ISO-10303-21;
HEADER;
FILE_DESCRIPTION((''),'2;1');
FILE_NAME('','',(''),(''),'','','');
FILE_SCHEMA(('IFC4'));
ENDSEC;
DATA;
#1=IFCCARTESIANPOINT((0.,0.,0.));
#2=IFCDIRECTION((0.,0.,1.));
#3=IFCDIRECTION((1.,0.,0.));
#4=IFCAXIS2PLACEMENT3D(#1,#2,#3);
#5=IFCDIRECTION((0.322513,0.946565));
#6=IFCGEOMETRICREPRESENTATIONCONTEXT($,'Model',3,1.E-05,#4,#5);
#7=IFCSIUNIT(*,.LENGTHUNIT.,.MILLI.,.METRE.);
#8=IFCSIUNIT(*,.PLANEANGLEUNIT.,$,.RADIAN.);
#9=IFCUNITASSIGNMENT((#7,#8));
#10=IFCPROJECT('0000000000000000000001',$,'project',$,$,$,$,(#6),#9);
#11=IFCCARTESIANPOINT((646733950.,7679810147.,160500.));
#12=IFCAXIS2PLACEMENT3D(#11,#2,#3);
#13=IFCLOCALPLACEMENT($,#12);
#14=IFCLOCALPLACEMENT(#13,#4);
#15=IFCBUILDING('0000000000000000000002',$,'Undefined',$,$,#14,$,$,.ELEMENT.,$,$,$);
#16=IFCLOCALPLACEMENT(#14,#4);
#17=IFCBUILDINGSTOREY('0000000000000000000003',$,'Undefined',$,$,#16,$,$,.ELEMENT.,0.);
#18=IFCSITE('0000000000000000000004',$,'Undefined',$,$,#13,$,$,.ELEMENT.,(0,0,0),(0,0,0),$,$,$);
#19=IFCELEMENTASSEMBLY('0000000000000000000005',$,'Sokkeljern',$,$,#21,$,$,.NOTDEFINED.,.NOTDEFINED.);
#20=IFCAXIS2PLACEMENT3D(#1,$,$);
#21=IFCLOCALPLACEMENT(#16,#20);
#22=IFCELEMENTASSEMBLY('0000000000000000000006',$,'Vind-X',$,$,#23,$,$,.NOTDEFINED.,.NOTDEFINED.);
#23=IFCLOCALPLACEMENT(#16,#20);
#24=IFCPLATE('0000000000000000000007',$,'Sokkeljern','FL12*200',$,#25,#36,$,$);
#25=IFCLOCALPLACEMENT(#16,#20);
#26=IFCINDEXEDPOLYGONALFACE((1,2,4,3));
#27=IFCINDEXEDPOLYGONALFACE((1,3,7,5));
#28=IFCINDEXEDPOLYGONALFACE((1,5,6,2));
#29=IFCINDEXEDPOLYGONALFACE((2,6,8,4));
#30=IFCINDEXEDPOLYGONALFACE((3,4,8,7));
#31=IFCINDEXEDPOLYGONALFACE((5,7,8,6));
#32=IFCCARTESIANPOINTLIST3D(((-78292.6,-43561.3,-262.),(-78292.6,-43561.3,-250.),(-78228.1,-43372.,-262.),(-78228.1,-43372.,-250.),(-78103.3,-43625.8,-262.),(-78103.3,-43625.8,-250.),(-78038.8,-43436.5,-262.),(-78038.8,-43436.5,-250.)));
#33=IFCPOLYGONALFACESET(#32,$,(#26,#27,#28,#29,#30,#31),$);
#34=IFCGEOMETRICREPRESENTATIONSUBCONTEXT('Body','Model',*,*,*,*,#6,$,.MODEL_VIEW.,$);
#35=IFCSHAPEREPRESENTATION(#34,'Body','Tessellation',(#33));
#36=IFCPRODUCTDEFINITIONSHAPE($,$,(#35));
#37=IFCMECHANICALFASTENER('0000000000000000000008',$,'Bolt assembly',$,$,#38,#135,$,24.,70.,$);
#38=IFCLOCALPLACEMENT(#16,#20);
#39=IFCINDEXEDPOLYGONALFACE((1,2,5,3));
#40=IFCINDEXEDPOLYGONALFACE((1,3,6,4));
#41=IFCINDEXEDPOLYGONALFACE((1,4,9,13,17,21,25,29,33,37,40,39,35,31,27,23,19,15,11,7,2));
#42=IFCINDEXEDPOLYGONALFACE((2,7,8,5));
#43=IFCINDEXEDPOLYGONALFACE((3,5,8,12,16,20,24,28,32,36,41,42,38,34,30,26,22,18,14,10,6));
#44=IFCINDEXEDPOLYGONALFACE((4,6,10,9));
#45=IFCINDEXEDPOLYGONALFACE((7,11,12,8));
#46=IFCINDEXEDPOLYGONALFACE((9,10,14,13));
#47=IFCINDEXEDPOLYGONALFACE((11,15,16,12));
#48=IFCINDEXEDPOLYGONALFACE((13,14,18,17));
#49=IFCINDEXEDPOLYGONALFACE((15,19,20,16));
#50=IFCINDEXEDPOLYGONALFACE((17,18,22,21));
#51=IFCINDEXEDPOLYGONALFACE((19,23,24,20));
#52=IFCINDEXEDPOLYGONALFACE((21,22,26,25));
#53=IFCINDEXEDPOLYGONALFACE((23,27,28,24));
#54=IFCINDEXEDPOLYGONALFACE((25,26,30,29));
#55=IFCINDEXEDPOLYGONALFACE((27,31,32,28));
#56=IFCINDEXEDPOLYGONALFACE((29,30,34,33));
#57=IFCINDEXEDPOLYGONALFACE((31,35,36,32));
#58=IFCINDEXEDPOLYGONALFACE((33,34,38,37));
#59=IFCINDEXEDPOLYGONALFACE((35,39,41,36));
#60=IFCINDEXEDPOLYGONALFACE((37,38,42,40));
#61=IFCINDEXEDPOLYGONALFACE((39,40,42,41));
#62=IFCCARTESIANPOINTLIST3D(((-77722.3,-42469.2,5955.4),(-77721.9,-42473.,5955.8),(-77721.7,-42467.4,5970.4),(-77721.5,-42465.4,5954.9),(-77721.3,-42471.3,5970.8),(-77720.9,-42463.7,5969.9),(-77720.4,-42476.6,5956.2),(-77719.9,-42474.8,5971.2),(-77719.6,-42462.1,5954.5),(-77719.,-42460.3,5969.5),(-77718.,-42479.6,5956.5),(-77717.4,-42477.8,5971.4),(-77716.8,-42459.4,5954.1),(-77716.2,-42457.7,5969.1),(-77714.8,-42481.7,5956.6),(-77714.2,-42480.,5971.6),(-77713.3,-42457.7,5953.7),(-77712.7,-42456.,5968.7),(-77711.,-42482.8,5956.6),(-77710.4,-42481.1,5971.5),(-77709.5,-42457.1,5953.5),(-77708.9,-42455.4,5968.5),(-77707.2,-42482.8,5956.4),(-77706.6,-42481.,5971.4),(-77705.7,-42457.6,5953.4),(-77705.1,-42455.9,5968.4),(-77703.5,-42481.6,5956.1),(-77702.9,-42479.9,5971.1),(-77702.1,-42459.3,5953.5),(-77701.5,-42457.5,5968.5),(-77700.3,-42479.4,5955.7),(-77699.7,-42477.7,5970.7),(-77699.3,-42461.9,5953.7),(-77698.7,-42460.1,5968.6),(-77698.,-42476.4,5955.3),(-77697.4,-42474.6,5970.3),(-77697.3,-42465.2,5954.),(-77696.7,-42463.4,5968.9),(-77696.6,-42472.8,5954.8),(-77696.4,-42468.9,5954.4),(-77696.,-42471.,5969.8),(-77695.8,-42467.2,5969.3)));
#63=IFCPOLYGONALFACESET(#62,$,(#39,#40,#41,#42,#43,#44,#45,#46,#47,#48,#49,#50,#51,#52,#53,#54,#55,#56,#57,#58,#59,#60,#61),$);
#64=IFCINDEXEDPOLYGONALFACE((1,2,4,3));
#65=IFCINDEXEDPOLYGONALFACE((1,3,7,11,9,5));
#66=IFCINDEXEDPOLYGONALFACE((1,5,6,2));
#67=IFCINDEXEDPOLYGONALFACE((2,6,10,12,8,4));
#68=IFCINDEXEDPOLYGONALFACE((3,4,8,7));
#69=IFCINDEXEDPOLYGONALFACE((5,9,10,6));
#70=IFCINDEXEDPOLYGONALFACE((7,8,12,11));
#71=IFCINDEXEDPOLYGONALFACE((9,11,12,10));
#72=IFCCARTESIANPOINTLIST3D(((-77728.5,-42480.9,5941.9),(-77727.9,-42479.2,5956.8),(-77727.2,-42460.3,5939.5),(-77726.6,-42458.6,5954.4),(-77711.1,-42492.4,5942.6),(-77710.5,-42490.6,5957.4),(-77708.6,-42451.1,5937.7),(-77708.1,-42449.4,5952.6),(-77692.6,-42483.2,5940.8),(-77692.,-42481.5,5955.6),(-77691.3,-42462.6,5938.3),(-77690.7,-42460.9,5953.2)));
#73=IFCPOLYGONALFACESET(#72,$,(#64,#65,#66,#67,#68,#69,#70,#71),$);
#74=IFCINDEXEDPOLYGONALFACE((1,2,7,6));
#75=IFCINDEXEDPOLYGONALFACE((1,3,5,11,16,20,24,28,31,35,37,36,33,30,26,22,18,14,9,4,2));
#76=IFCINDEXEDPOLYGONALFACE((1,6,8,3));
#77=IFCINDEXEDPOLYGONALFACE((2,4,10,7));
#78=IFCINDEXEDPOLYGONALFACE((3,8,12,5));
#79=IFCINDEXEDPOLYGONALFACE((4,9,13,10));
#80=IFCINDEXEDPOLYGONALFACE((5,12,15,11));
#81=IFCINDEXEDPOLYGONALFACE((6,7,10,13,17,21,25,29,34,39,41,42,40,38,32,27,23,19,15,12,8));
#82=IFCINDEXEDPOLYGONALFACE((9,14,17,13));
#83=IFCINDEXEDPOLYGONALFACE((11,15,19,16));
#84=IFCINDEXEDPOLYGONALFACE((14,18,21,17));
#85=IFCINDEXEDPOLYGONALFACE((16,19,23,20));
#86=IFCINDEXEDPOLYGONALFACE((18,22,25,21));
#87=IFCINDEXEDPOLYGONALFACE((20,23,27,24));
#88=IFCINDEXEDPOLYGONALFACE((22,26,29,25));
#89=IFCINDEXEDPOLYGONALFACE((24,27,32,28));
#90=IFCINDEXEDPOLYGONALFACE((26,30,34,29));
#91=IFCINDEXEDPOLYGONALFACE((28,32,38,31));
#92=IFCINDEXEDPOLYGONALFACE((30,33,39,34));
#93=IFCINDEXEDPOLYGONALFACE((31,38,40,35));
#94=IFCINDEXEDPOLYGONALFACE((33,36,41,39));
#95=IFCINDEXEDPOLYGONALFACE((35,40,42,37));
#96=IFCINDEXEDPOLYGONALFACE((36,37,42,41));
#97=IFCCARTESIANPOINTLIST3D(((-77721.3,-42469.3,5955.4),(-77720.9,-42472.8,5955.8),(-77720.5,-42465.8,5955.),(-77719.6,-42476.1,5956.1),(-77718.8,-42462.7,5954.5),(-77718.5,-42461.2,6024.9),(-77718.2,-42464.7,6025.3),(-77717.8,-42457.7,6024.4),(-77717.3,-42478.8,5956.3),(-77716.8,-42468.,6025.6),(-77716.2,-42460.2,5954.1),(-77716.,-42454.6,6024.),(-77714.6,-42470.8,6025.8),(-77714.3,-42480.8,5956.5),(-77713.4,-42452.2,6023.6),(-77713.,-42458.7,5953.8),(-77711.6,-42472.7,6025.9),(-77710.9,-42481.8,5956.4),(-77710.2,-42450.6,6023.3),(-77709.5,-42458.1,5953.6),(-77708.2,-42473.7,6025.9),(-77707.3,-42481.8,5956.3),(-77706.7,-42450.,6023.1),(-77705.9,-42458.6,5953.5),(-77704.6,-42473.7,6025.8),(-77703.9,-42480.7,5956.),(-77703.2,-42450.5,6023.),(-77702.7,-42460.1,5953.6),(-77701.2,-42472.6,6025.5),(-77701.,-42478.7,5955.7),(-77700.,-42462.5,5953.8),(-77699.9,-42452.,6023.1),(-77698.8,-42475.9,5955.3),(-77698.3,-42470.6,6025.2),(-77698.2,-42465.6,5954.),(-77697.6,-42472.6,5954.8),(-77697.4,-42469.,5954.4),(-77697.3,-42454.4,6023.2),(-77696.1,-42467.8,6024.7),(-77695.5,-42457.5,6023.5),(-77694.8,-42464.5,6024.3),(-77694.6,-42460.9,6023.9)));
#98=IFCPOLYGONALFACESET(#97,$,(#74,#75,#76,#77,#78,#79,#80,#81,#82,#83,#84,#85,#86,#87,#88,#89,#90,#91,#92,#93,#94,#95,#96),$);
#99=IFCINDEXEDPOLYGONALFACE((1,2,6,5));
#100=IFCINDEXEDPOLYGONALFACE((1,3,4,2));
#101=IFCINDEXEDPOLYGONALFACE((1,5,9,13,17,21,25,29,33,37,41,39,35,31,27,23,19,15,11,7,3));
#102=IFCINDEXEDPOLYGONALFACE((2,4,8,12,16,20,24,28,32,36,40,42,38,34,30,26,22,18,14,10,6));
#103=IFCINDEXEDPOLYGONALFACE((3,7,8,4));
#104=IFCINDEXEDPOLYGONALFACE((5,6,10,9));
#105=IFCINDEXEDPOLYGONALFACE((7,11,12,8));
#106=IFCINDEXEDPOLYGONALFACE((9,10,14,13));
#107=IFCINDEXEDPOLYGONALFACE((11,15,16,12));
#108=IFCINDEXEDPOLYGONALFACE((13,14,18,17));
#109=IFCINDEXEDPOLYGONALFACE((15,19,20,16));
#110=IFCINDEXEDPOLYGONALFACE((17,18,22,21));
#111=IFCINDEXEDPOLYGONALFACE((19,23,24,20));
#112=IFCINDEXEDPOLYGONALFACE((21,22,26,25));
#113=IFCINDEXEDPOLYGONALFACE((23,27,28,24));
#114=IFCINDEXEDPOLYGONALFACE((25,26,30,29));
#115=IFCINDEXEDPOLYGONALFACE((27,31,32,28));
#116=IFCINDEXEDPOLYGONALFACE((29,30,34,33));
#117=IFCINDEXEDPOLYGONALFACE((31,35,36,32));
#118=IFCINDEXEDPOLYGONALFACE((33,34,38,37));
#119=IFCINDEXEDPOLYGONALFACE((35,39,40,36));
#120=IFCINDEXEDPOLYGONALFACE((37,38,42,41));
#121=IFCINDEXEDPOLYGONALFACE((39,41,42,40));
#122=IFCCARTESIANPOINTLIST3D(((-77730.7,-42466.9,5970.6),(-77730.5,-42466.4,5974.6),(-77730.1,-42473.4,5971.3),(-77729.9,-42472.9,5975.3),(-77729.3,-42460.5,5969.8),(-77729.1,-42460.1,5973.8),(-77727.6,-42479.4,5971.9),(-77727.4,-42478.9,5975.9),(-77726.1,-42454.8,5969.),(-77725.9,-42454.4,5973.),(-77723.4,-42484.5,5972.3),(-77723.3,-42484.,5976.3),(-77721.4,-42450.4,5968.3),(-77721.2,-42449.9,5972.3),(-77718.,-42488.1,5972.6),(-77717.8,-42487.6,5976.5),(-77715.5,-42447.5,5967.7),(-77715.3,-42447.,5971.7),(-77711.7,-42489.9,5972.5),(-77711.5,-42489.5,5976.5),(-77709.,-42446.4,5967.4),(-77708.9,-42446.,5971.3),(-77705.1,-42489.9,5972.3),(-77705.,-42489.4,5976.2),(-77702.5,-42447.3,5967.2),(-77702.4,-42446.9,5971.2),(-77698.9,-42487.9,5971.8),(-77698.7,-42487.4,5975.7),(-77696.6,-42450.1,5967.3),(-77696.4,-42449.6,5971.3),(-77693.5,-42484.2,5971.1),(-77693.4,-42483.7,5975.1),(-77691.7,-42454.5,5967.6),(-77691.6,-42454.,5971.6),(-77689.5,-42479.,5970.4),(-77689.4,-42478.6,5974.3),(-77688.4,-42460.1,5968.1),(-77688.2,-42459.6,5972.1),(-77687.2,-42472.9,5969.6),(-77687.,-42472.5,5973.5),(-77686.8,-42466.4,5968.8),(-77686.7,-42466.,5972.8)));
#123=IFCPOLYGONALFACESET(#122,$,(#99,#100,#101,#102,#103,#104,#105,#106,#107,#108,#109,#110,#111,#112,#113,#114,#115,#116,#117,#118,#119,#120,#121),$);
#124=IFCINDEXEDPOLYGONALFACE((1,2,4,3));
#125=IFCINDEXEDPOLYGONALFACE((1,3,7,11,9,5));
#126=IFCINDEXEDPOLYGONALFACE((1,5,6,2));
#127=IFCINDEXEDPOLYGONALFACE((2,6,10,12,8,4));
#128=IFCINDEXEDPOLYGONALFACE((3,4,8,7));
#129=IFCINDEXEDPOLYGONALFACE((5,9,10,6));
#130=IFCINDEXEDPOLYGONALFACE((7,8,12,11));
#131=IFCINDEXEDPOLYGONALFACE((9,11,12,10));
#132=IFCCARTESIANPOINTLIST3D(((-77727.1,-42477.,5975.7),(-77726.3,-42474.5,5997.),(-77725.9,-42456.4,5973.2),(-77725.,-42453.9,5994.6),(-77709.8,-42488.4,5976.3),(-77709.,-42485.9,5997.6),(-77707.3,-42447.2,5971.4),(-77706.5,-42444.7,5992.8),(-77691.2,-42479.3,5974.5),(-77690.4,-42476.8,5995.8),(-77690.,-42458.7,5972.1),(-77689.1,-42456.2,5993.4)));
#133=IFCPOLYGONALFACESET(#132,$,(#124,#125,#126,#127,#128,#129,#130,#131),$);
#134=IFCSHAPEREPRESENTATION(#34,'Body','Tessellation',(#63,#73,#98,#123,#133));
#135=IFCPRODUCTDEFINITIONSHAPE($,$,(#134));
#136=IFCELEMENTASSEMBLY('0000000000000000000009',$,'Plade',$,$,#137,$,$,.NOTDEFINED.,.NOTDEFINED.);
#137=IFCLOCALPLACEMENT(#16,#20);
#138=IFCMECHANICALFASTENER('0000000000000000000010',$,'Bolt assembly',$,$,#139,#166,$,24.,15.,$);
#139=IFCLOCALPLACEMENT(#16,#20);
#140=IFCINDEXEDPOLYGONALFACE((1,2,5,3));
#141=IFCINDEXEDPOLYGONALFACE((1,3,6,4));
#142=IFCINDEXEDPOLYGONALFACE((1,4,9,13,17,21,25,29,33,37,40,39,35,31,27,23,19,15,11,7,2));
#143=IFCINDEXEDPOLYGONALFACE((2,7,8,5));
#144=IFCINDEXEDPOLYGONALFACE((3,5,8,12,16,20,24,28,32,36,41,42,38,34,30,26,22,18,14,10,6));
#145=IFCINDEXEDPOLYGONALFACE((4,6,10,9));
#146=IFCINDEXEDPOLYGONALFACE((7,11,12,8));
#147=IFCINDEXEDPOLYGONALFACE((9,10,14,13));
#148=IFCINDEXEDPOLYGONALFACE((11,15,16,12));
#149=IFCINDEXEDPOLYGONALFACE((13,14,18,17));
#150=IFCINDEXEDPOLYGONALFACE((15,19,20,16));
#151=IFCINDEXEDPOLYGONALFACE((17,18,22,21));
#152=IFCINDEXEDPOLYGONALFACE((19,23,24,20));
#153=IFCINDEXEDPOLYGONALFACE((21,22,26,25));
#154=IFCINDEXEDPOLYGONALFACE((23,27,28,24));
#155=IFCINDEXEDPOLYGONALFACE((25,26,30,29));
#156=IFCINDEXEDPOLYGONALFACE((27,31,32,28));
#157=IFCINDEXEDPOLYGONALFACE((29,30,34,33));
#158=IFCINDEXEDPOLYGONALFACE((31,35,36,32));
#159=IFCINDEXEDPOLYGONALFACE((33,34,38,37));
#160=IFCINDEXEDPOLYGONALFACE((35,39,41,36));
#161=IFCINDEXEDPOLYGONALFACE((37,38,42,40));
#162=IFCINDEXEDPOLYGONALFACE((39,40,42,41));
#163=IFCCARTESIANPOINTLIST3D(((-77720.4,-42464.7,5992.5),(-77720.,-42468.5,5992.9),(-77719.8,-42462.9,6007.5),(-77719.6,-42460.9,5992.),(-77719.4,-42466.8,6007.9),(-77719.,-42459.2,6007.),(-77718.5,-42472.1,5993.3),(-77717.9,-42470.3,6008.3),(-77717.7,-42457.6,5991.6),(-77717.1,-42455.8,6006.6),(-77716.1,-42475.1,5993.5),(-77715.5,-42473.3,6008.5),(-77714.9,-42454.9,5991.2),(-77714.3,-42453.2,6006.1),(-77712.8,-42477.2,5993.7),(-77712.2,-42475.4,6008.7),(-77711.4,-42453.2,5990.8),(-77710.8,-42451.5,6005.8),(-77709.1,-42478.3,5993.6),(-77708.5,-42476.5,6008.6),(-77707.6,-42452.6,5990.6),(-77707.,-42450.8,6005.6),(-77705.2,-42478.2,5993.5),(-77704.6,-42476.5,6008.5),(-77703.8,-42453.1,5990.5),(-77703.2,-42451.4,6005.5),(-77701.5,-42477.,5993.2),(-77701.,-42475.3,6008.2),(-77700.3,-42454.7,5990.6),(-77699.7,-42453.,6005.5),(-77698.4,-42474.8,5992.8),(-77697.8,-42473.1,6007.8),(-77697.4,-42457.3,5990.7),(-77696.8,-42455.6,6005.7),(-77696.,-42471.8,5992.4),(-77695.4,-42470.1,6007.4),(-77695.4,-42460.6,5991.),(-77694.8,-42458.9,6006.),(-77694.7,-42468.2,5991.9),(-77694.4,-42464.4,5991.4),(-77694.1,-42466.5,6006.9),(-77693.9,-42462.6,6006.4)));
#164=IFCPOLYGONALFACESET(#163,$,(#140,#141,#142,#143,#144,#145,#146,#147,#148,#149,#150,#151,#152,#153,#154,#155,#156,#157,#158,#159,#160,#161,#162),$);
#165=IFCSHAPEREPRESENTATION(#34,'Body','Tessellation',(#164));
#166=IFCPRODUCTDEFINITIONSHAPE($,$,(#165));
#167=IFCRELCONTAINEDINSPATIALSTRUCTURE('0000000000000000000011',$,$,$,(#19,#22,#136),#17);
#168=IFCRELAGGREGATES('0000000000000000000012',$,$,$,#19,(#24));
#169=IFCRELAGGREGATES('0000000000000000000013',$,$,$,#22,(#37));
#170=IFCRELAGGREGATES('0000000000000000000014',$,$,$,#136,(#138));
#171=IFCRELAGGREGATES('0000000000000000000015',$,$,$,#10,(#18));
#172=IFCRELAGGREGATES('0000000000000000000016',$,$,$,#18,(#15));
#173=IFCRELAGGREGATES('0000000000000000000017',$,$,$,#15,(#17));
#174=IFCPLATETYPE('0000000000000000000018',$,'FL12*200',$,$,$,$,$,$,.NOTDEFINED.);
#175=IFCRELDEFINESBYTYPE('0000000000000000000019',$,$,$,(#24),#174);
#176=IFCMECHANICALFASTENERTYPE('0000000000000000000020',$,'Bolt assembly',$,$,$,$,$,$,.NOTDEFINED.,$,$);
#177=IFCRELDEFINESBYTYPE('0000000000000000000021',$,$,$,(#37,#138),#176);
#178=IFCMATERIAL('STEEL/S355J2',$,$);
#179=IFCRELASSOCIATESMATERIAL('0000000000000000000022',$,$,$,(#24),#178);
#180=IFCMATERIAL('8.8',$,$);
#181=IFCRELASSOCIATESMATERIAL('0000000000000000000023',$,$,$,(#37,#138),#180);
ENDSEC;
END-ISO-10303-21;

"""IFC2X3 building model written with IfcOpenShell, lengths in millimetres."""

from ifc_helpers import new_model, si_unit, direction, frame, origin_with_axes, origin_2d_with_axis, place, context, subcontext, project, spatial, polyline, circle, outline, extrude, source, transform, mapped, material, type_object, element, aggregate, save


model = new_model("IFC2X3")

# Units and contexts
model_context = context("Model", 3, precision=1e-05, world=origin_with_axes(), true_north=direction((0.322513, 0.946565)))
body_context = subcontext(model_context, "Body", "Model", "MODEL_VIEW")
ifc_project = project(units=[si_unit("LENGTHUNIT", "METRE", prefix="MILLI"), si_unit("PLANEANGLEUNIT", "RADIAN")], contexts=[model_context])

# Site, building, storey
site_placement = place(None, frame((646733950.0, 7679810147.0, 160500.0), z_axis=(0.0, 0.0, 1.0), x_axis=(1.0, 0.0, 0.0)))
site = spatial("IfcSite", under=ifc_project, at=site_placement, Name="Undefined", CompositionType="ELEMENT", RefLatitude=(0, 0, 0), RefLongitude=(0, 0, 0))
building_placement = place(site_placement, origin_with_axes())
building = spatial("IfcBuilding", under=site, at=building_placement, Name="Undefined", CompositionType="ELEMENT")
storey_placement = place(building_placement, origin_with_axes())
storey = spatial("IfcBuildingStorey", under=building, at=storey_placement, Name="Undefined", CompositionType="ELEMENT", Elevation=0.0)

# Element assembly
ifc_material_1 = material(Name="STEEL/S355J2")
assembly_1_placement = place(storey_placement, origin_with_axes())
assembly_1 = element("IfcElementAssembly", 1, at=assembly_1_placement, inside=storey, Name="Sokkeljern", AssemblyPlace="NOTDEFINED", PredefinedType="NOTDEFINED")

# Element assembly
assembly_2_placement = place(storey_placement, origin_with_axes())
assembly_2 = element("IfcElementAssembly", 2, at=assembly_2_placement, inside=storey, Name="Vind-X", AssemblyPlace="NOTDEFINED", PredefinedType="NOTDEFINED")

# Plate
plate_type_1 = type_object("IfcPlateType", Name="FL12*200", PredefinedType="NOTDEFINED")
plate_1_placement = place(assembly_1_placement, frame((-78038.8, -43436.5, -256.0), z_axis=(0.0, 0.0, 1.0), x_axis=(-0.946565, 0.322513, 0.0)))
plate_1 = element("IfcPlate", 3, at=plate_1_placement, type_object=plate_type_1, material=ifc_material_1, Name="Sokkeljern", Description="FL12*200", context=body_context, shape_type="SweptSolid", body=[
    extrude(outline(polyline([(0.0, 0.0), (200.0, 0.0), (200.0, 200.0), (0.0, 200.0), (0.0, 0.0)])), frame((0.0, 0.0, -6.0), z_axis=(0.0, 0.0, 1.0), x_axis=(1.0, 0.0, 0.0)), (0.0, 0.0, 1.0), 12.0),
])
aggregate(assembly_1, [plate_1])

# Shared definitions
ifc_material_2 = material(Name="8.8")
mechanical_fastener_type = type_object("IfcMechanicalFastenerType", Name="Bolt assembly")

# Mechanical fastener
shared_shape_1 = source(origin_with_axes(), body_context, "Body", "SweptSolid", [
    extrude(circle(Radius=13.0, at=origin_2d_with_axis()), frame((0.0, 0.0, 0.0), z_axis=(0.0, 1.0, 0.0), x_axis=(1.0, 0.0, 0.0)), (0.0, 0.0, 1.0), 15.1),
    extrude(outline(polyline([(18.0, -10.4), (18.0, 10.4), (0.0, 20.8), (-18.0, 10.4), (-18.0, -10.4), (0.0, -20.8), (18.0, -10.4)])), frame((0.0, -15.0, 0.0), z_axis=(0.0, 1.0, 0.0), x_axis=(1.0, 0.0, 0.0)), (0.0, 0.0, 1.0), 15.0),
    extrude(circle(Radius=12.0, at=origin_2d_with_axis()), frame((0.0, 0.0, 0.0), z_axis=(0.0, 1.0, 0.0), x_axis=(1.0, 0.0, 0.0)), (0.0, 0.0, 1.0), 70.0),
    extrude(circle(Radius=22.0, at=origin_2d_with_axis()), frame((0.0, 15.0, 0.0), z_axis=(0.0, 1.0, 0.0), x_axis=(1.0, 0.0, 0.0)), (0.0, 0.0, 1.0), 4.0),
    extrude(outline(polyline([(18.0, -10.4), (18.0, 10.4), (0.0, 20.8), (-18.0, 10.4), (-18.0, -10.4), (0.0, -20.8), (18.0, -10.4)])), frame((0.0, 19.0, 0.0), z_axis=(0.0, 1.0, 0.0), x_axis=(1.0, 0.0, 0.0)), (0.0, 0.0, 1.0), 21.5),
])
mechanical_fastener_1_placement = place(assembly_2_placement, frame((-77709.3, -42470.0, 5955.0), z_axis=(-0.893742, -0.440152, 0.086548), x_axis=(0.446855, -0.890482, 0.0858)))
mechanical_fastener_1 = element("IfcMechanicalFastener", 4, at=mechanical_fastener_1_placement, type_object=mechanical_fastener_type, material=ifc_material_2, Name="Bolt assembly", NominalDiameter=24.0, NominalLength=70.0, context=body_context, shape_type="MappedRepresentation", body=[
    mapped(shared_shape_1, transform((0.0, 0.0, 0.0))),
])
aggregate(assembly_2, [mechanical_fastener_1])

# Element assembly, mechanical fastener
assembly_3_placement = place(storey_placement, origin_with_axes())
assembly_3 = element("IfcElementAssembly", 5, at=assembly_3_placement, inside=storey, Name="Plade", AssemblyPlace="NOTDEFINED", PredefinedType="NOTDEFINED")
shared_shape_2 = source(origin_with_axes(), body_context, "Body", "SweptSolid", [
    extrude(circle(Radius=13.0, at=origin_2d_with_axis()), frame((0.0, -15.0, 0.0), z_axis=(0.0, 1.0, 0.0), x_axis=(1.0, 0.0, 0.0)), (0.0, 0.0, 1.0), 15.1),
])
mechanical_fastener_2_placement = place(assembly_3_placement, frame((-77707.4, -42465.5, 5992.2), z_axis=(0.892615, 0.442393, -0.086764), x_axis=(0.449104, -0.889371, 0.085582)))
mechanical_fastener_2 = element("IfcMechanicalFastener", 6, at=mechanical_fastener_2_placement, type_object=mechanical_fastener_type, material=ifc_material_2, Name="Bolt assembly", NominalDiameter=24.0, NominalLength=15.0, context=body_context, shape_type="MappedRepresentation", body=[
    mapped(shared_shape_2, transform((0.0, 0.0, 0.0))),
])
aggregate(assembly_3, [mechanical_fastener_2])

save(model, "model.ifc")
